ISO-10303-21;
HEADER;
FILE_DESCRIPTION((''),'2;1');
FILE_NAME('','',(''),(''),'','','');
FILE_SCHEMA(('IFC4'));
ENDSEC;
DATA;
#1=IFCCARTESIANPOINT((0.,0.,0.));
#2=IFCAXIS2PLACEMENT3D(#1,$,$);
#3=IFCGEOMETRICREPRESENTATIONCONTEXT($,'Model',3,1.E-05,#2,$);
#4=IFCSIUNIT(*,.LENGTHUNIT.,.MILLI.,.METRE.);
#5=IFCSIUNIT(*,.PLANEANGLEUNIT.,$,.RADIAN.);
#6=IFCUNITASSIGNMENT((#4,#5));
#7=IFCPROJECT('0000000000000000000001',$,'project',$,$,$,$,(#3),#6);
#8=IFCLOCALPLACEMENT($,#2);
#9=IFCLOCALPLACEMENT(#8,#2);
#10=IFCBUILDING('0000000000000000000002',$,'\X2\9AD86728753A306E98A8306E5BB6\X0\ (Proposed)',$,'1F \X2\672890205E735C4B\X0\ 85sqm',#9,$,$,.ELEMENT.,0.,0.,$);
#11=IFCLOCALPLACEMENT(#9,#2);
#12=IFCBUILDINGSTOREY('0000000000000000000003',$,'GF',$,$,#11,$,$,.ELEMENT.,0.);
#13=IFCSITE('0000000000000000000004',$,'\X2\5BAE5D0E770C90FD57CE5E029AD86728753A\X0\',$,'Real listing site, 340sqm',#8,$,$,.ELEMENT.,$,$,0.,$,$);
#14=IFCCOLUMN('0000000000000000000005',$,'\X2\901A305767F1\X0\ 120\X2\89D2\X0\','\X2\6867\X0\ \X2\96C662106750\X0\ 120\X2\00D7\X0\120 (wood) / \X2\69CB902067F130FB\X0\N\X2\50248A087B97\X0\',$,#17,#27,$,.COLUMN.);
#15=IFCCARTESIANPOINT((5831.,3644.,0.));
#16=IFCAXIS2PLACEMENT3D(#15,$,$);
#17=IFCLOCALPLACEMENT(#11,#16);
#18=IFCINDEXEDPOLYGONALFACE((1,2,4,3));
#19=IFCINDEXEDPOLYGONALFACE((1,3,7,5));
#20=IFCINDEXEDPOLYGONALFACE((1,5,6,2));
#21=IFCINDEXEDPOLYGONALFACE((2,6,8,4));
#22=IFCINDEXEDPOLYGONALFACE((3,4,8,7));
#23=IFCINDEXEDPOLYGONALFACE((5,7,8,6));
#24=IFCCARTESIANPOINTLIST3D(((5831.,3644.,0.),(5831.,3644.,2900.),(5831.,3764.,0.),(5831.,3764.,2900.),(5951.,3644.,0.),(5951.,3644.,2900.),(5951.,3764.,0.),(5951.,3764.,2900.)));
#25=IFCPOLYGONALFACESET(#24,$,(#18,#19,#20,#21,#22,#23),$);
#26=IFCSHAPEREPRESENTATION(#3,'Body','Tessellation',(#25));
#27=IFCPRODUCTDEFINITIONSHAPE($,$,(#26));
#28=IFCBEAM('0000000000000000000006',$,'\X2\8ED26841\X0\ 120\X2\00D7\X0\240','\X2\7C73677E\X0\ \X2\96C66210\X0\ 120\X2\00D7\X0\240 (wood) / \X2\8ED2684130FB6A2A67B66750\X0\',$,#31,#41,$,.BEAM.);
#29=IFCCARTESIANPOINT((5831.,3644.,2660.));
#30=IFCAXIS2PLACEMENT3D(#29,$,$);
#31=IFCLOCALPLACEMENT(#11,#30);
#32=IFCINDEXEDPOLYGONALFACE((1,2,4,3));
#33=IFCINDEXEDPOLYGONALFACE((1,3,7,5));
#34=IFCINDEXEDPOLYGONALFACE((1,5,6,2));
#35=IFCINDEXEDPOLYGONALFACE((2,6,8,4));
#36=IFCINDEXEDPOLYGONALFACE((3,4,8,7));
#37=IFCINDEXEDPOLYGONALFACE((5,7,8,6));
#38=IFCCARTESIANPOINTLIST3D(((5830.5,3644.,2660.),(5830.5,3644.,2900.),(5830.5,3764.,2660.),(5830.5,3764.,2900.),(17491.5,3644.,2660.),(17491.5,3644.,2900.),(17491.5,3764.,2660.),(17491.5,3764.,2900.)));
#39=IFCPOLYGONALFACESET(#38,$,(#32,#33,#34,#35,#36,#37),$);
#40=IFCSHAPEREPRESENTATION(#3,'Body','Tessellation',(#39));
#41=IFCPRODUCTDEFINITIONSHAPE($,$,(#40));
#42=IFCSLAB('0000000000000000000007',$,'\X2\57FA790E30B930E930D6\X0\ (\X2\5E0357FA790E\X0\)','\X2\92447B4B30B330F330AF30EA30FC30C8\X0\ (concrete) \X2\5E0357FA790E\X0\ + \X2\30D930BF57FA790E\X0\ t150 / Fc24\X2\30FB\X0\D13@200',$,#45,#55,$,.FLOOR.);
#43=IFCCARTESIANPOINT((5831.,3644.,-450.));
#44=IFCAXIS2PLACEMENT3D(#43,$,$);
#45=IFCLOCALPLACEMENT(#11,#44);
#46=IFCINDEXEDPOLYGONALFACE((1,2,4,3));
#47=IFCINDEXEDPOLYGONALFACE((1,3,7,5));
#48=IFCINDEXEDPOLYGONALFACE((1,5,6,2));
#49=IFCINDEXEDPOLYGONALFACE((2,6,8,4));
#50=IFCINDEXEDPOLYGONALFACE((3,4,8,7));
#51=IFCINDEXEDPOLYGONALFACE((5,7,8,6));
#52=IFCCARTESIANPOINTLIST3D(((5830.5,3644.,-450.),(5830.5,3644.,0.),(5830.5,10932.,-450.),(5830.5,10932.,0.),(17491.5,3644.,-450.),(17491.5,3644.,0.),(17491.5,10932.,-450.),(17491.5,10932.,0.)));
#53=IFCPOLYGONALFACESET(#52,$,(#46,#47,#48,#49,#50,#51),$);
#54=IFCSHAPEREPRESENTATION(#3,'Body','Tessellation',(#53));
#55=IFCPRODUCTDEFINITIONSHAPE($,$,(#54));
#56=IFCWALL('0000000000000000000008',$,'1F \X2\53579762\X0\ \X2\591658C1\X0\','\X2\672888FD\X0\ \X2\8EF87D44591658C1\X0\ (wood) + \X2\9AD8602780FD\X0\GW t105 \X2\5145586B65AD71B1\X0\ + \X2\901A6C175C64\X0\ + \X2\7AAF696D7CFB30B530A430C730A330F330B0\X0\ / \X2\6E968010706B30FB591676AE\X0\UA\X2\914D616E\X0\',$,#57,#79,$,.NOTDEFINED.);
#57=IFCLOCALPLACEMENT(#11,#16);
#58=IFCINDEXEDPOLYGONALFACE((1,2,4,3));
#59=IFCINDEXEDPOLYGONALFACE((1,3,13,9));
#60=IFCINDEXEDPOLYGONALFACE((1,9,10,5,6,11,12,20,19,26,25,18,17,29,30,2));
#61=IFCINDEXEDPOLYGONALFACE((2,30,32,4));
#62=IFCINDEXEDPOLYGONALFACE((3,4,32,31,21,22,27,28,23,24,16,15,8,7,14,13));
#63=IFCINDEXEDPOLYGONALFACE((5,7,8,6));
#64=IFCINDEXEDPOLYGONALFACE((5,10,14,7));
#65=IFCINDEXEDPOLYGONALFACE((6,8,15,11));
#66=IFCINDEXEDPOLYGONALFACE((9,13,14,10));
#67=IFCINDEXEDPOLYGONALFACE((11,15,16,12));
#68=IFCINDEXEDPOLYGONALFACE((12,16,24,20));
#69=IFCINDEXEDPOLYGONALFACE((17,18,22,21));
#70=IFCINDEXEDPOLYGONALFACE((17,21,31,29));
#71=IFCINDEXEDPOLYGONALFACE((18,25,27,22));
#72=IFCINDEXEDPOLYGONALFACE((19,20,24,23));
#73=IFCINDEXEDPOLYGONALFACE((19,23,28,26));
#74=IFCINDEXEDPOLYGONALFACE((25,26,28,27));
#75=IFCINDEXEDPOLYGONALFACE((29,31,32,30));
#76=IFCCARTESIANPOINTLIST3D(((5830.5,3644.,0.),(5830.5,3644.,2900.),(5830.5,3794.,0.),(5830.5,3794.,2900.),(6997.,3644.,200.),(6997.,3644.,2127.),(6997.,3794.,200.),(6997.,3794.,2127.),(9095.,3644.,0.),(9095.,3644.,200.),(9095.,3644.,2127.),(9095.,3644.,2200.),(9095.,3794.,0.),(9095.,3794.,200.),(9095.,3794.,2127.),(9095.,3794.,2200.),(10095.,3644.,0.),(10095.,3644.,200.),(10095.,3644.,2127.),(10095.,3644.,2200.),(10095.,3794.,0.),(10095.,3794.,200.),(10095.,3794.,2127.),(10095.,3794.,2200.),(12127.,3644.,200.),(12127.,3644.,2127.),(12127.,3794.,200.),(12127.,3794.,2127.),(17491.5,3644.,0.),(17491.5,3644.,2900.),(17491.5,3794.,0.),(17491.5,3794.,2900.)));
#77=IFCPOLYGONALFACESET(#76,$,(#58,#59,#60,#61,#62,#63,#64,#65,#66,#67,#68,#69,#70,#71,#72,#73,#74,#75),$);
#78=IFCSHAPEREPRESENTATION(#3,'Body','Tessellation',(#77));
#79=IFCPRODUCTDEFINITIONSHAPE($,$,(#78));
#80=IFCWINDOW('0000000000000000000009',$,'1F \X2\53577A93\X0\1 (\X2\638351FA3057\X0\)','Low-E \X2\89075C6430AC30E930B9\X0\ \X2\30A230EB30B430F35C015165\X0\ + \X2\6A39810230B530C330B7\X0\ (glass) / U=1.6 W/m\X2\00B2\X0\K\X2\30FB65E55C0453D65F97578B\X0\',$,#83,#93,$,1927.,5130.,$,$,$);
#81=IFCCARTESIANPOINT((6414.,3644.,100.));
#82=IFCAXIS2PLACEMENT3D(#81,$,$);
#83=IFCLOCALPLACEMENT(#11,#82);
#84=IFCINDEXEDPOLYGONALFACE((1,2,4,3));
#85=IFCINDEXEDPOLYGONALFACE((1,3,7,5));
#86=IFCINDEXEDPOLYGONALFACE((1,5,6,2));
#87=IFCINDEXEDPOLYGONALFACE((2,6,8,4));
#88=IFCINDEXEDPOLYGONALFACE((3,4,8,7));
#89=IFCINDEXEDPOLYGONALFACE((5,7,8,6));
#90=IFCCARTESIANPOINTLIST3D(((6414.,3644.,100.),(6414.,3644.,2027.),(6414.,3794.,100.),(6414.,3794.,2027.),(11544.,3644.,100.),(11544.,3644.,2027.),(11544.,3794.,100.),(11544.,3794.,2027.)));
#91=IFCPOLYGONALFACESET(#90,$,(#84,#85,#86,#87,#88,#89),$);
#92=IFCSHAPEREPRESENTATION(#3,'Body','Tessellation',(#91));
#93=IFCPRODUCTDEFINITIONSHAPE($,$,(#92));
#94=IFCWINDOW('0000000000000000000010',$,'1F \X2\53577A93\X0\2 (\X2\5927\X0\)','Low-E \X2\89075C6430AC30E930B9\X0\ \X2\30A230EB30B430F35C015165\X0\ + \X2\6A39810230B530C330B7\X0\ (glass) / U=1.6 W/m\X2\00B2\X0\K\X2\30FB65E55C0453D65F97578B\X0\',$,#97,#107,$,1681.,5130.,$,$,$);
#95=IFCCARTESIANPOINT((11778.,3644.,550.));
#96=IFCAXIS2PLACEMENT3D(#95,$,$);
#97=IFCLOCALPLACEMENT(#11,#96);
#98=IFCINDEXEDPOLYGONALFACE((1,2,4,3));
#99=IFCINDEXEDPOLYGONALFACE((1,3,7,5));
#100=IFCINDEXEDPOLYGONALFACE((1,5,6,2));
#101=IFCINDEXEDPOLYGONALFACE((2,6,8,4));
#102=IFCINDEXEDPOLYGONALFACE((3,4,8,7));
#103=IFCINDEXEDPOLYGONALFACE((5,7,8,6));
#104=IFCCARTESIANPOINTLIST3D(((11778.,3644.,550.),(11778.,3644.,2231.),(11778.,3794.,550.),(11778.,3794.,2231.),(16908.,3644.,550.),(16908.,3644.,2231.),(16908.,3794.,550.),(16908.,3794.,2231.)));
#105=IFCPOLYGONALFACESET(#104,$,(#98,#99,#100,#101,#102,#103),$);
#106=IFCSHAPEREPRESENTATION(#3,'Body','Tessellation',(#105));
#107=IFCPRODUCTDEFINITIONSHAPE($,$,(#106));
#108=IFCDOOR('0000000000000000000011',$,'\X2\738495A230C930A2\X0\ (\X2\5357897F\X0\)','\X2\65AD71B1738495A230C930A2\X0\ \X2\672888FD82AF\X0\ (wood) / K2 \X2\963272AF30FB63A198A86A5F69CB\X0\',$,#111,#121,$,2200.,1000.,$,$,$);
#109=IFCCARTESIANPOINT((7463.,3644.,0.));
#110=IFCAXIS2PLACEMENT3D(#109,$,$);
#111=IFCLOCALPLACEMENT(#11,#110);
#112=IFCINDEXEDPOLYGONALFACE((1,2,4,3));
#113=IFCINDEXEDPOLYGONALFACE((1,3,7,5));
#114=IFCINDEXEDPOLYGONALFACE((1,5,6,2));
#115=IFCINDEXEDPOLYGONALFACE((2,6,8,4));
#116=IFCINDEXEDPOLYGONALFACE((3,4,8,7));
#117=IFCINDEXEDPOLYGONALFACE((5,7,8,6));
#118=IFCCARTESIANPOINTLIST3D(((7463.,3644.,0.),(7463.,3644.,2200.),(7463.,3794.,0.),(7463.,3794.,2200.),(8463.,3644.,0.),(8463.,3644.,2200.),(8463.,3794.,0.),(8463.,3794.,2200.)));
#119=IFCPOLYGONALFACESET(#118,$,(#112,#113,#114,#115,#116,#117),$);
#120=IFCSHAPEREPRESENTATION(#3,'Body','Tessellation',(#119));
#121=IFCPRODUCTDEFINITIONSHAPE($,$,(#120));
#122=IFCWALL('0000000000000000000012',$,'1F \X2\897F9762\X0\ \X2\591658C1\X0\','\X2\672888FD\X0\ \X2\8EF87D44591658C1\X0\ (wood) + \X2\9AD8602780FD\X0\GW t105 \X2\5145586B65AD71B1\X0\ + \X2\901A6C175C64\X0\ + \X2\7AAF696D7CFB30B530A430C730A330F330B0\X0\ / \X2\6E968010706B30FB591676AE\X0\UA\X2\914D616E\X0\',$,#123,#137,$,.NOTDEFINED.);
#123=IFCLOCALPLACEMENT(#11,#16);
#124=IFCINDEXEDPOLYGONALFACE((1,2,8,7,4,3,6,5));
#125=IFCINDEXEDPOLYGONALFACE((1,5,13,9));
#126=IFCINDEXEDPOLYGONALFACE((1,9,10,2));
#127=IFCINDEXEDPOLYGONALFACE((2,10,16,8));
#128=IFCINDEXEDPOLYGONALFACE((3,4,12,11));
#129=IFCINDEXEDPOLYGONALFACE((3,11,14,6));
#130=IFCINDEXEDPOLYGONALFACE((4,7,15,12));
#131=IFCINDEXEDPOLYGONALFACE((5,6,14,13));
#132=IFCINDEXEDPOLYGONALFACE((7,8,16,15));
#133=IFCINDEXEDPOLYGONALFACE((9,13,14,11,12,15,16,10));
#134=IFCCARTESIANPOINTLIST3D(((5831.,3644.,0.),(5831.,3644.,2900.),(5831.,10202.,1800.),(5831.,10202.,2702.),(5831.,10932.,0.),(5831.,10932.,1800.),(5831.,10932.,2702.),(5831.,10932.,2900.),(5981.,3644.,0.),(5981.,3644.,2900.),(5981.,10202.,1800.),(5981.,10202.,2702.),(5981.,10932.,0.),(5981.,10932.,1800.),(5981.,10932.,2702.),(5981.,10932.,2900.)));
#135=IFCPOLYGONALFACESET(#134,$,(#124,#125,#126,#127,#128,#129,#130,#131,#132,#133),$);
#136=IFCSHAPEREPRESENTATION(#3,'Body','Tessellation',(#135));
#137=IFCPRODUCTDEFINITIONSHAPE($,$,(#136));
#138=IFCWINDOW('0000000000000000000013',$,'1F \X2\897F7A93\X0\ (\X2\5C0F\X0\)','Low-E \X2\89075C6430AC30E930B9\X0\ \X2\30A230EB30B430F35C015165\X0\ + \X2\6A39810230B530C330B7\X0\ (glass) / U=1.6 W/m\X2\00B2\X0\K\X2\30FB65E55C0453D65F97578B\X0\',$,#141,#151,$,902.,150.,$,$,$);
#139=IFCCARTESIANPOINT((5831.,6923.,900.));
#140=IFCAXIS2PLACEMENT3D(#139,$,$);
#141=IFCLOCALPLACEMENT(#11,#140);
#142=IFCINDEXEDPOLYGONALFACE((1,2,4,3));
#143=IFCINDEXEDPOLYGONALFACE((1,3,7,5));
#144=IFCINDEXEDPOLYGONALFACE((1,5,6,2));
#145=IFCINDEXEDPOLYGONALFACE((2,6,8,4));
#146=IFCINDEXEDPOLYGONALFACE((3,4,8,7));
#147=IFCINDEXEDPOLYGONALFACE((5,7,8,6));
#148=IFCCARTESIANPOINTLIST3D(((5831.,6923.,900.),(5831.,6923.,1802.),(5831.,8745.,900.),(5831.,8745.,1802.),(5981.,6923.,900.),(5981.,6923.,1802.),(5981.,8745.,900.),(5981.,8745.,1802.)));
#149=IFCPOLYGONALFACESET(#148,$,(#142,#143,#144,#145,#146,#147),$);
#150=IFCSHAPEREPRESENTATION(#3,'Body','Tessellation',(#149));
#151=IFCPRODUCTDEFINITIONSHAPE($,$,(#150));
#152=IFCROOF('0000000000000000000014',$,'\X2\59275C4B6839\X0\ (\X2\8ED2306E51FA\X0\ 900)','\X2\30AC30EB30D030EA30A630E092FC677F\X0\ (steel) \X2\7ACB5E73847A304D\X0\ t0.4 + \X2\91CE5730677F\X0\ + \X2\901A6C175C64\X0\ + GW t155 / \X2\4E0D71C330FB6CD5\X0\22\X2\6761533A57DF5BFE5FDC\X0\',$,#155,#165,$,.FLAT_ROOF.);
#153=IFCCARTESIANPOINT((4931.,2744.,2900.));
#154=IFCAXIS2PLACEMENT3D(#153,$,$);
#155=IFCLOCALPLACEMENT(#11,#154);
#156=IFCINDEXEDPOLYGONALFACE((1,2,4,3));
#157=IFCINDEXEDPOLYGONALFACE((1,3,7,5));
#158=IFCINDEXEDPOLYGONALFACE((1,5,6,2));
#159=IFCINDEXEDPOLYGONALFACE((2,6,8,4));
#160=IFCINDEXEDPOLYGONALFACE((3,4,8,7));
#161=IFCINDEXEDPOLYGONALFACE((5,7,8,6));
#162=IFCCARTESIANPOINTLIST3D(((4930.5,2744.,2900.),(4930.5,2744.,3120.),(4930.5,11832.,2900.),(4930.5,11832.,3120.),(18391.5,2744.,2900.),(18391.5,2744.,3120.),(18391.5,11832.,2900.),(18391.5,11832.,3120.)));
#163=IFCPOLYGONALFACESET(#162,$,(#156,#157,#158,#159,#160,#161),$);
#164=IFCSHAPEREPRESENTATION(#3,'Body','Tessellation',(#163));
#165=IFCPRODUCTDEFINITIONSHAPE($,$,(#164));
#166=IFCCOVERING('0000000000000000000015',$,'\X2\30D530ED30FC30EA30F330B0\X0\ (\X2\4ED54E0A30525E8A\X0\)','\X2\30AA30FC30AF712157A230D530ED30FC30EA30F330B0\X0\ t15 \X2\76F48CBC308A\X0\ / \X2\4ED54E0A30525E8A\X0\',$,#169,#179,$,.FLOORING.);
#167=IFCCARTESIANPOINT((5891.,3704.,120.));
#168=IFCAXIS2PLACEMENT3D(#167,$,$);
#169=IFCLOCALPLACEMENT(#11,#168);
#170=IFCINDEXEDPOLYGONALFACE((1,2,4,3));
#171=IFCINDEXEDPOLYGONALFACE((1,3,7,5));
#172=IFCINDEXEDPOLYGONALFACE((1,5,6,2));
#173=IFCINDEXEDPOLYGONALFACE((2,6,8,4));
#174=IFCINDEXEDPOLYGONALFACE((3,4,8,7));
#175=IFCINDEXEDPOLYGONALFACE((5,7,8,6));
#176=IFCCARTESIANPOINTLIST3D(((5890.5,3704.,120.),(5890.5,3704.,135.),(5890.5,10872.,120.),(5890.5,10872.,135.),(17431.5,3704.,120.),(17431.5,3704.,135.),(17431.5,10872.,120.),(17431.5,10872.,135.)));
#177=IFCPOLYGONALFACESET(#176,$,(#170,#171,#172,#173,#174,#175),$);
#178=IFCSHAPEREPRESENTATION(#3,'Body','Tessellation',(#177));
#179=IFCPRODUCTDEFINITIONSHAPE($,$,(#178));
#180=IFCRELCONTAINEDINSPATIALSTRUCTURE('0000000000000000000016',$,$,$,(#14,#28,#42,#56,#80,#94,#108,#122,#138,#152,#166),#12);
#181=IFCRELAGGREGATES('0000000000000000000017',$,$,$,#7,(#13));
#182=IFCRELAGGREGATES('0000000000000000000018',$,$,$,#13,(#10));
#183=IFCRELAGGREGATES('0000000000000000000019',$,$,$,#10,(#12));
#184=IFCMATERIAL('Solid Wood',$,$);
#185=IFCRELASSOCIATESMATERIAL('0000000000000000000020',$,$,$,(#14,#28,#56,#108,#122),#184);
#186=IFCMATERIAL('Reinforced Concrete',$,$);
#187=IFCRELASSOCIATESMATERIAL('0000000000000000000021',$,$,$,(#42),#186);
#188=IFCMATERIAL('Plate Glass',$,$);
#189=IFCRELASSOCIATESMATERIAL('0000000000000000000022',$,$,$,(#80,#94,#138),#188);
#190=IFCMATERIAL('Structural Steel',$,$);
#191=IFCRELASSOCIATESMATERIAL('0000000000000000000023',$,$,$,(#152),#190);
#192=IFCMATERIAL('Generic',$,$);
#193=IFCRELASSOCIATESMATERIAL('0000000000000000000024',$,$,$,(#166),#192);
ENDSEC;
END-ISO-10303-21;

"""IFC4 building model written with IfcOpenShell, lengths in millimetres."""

from ifc_helpers import new_model, si_unit, frame, frame_2d, origin, place, context, project, spatial, rectangle, extrude, material, element, fill, save


model = new_model("IFC4")

# Units and contexts
model_context = context("Model", 3, precision=1e-05, world=origin())
ifc_project = project(units=[si_unit("LENGTHUNIT", "METRE", prefix="MILLI"), si_unit("PLANEANGLEUNIT", "RADIAN")], contexts=[model_context])

# Site, building, storey
site_placement = place(None, origin())
site = spatial("IfcSite", under=ifc_project, at=site_placement, Name="宮崎県都城市高木町", ObjectType="Real listing site, 340sqm", CompositionType="ELEMENT", RefElevation=0.0)
building_placement = place(site_placement, origin())
building = spatial("IfcBuilding", under=site, at=building_placement, Name="高木町の風の家 (Proposed)", ObjectType="1F 木造平屋 85sqm", CompositionType="ELEMENT", ElevationOfRefHeight=0.0, ElevationOfTerrain=0.0)
storey_placement = place(building_placement, origin())
storey = spatial("IfcBuildingStorey", under=building, at=storey_placement, Name="GF", CompositionType="ELEMENT", Elevation=0.0)

# Column
ifc_material_1 = material(Name="Solid Wood")
column_1_placement = place(storey_placement, frame((5831.0, 3644.0, 0.0)))
element("IfcColumn", 1, at=column_1_placement, inside=storey, material=ifc_material_1, Name="通し柱 120角", Description="桧 集成材 120×120 (wood) / 構造柱・N値計算", PredefinedType="COLUMN", context=model_context, shape_type="SweptSolid", body=[
    extrude(rectangle(XDim=120.0, YDim=120.0, at=frame_2d((60.0, 60.0))), frame((5831.0, 3644.0, 0.0)), (0.0, 0.0, 1.0), 2900.0),
])

# Beam
beam_1_placement = place(storey_placement, frame((5831.0, 3644.0, 2660.0)))
element("IfcBeam", 2, at=beam_1_placement, inside=storey, material=ifc_material_1, Name="軒桁 120×240", Description="米松 集成 120×240 (wood) / 軒桁・横架材", PredefinedType="BEAM", context=model_context, shape_type="SweptSolid", body=[
    extrude(rectangle(XDim=11661.0, YDim=120.0, at=frame_2d((5830.0, 60.0))), frame((5831.0, 3644.0, 2660.0)), (0.0, 0.0, 1.0), 240.0),
])

# Slab
ifc_material_2 = material(Name="Reinforced Concrete")
slab_1_placement = place(storey_placement, frame((5831.0, 3644.0, -450.0)))
element("IfcSlab", 3, at=slab_1_placement, inside=storey, material=ifc_material_2, Name="基礎スラブ (布基礎)", Description="鉄筋コンクリート (concrete) 布基礎 + ベタ基礎 t150 / Fc24・D13@200", PredefinedType="FLOOR", context=model_context, shape_type="SweptSolid", body=[
    extrude(rectangle(XDim=11661.0, YDim=7288.0, at=frame_2d((5830.0, 3644.0))), frame((5831.0, 3644.0, -450.0)), (0.0, 0.0, 1.0), 450.0),
])

# Wall, openings, windows, door
wall_1_placement = place(storey_placement, frame((5831.0, 3644.0, 0.0)))
wall_1 = element("IfcWall", 4, at=wall_1_placement, inside=storey, material=ifc_material_1, Name="1F 南面 外壁", Description="木製 軸組外壁 (wood) + 高性能GW t105 充填断熱 + 通気層 + 窯業系サイディング / 準耐火・外皮UA配慮", PredefinedType="NOTDEFINED", context=model_context, shape_type="SweptSolid", body=[
    extrude(rectangle(XDim=11661.0, YDim=150.0, at=frame_2d((5830.0, 75.0))), frame((5831.0, 3644.0, 0.0)), (0.0, 0.0, 1.0), 2900.0),
])
opening_1_placement = place(storey_placement, frame((6414.0, 3644.0, 100.0)))
opening_1 = element("IfcOpeningElement", 5, at=opening_1_placement, cuts=wall_1, PredefinedType="NOTDEFINED", context=model_context, shape_type="SweptSolid", body=[
    extrude(rectangle(XDim=5130.0, YDim=150.0, at=frame_2d((2565.0, 75.0))), frame((6414.0, 3644.0, 100.0)), (0.0, 0.0, 1.0), 1927.0),
])
opening_2_placement = place(storey_placement, frame((11778.0, 3644.0, 550.0)))
opening_2 = element("IfcOpeningElement", 6, at=opening_2_placement, cuts=wall_1, PredefinedType="NOTDEFINED", context=model_context, shape_type="SweptSolid", body=[
    extrude(rectangle(XDim=5130.0, YDim=150.0, at=frame_2d((2565.0, 75.0))), frame((11778.0, 3644.0, 550.0)), (0.0, 0.0, 1.0), 1681.0),
])
opening_3_placement = place(storey_placement, frame((7463.0, 3644.0, 0.0)))
opening_3 = element("IfcOpeningElement", 7, at=opening_3_placement, cuts=wall_1, PredefinedType="NOTDEFINED", context=model_context, shape_type="SweptSolid", body=[
    extrude(rectangle(XDim=1000.0, YDim=150.0, at=frame_2d((500.0, 75.0))), frame((7463.0, 3644.0, 0.0)), (0.0, 0.0, 1.0), 2200.0),
])
ifc_material_3 = material(Name="Plate Glass")
window_1_placement = place(storey_placement, frame((6414.0, 3644.0, 100.0)))
window_1 = element("IfcWindow", 8, at=window_1_placement, inside=storey, material=ifc_material_3, Name="1F 南窓1 (掃出し)", Description="Low-E 複層ガラス アルゴン封入 + 樹脂サッシ (glass) / U=1.6 W/m²K・日射取得型", OverallHeight=1927.0, OverallWidth=5130.0, context=model_context, shape_type="SweptSolid", body=[
    extrude(rectangle(XDim=5130.0, YDim=150.0, at=frame_2d((2565.0, 75.0))), frame((6414.0, 3644.0, 100.0)), (0.0, 0.0, 1.0), 1927.0),
])
fill(opening_1, window_1)
window_2_placement = place(storey_placement, frame((11778.0, 3644.0, 550.0)))
window_2 = element("IfcWindow", 9, at=window_2_placement, inside=storey, material=ifc_material_3, Name="1F 南窓2 (大)", Description="Low-E 複層ガラス アルゴン封入 + 樹脂サッシ (glass) / U=1.6 W/m²K・日射取得型", OverallHeight=1681.0, OverallWidth=5130.0, context=model_context, shape_type="SweptSolid", body=[
    extrude(rectangle(XDim=5130.0, YDim=150.0, at=frame_2d((2565.0, 75.0))), frame((11778.0, 3644.0, 550.0)), (0.0, 0.0, 1.0), 1681.0),
])
fill(opening_2, window_2)
door_placement = place(storey_placement, frame((7463.0, 3644.0, 0.0)))
door = element("IfcDoor", 10, at=door_placement, inside=storey, material=ifc_material_1, Name="玄関ドア (南西)", Description="断熱玄関ドア 木製芯 (wood) / K2 防犯・採風機構", OverallHeight=2200.0, OverallWidth=1000.0, context=model_context, shape_type="SweptSolid", body=[
    extrude(rectangle(XDim=1000.0, YDim=150.0, at=frame_2d((500.0, 75.0))), frame((7463.0, 3644.0, 0.0)), (0.0, 0.0, 1.0), 2200.0),
])
fill(opening_3, door)

# Wall, opening, window
wall_2_placement = place(storey_placement, frame((5831.0, 3644.0, 0.0)))
wall_2 = element("IfcWall", 11, at=wall_2_placement, inside=storey, material=ifc_material_1, Name="1F 西面 外壁", Description="木製 軸組外壁 (wood) + 高性能GW t105 充填断熱 + 通気層 + 窯業系サイディング / 準耐火・外皮UA配慮", PredefinedType="NOTDEFINED", context=model_context, shape_type="SweptSolid", body=[
    extrude(rectangle(XDim=150.0, YDim=7288.0, at=frame_2d((75.0, 3644.0))), frame((5831.0, 3644.0, 0.0)), (0.0, 0.0, 1.0), 2900.0),
])
opening_4_placement = place(storey_placement, frame((5831.0, 6923.0, 900.0)))
opening_4 = element("IfcOpeningElement", 12, at=opening_4_placement, cuts=wall_2, PredefinedType="NOTDEFINED", context=model_context, shape_type="SweptSolid", body=[
    extrude(rectangle(XDim=150.0, YDim=1822.0, at=frame_2d((75.0, 911.0))), frame((5831.0, 6923.0, 900.0)), (0.0, 0.0, 1.0), 902.0),
])
window_3_placement = place(storey_placement, frame((5831.0, 6923.0, 900.0)))
window_3 = element("IfcWindow", 13, at=window_3_placement, inside=storey, material=ifc_material_3, Name="1F 西窓 (小)", Description="Low-E 複層ガラス アルゴン封入 + 樹脂サッシ (glass) / U=1.6 W/m²K・日射取得型", OverallHeight=902.0, OverallWidth=150.0, context=model_context, shape_type="SweptSolid", body=[
    extrude(rectangle(XDim=150.0, YDim=1822.0, at=frame_2d((75.0, 911.0))), frame((5831.0, 6923.0, 900.0)), (0.0, 0.0, 1.0), 902.0),
])
fill(opening_4, window_3)

# Roof
ifc_material_4 = material(Name="Structural Steel")
roof_placement = place(storey_placement, frame((4931.0, 2744.0, 2900.0)))
element("IfcRoof", 14, at=roof_placement, inside=storey, material=ifc_material_4, Name="大屋根 (軒の出 900)", Description="ガルバリウム鋼板 (steel) 立平葺き t0.4 + 野地板 + 通気層 + GW t155 / 不燃・法22条区域対応", PredefinedType="FLAT_ROOF", context=model_context, shape_type="SweptSolid", body=[
    extrude(rectangle(XDim=13461.0, YDim=9088.0, at=frame_2d((6730.0, 4544.0))), frame((4931.0, 2744.0, 2900.0)), (0.0, 0.0, 1.0), 220.0),
])

# Covering
ifc_material_5 = material(Name="Generic")
covering_1_placement = place(storey_placement, frame((5891.0, 3704.0, 120.0)))
element("IfcCovering", 15, at=covering_1_placement, inside=storey, material=ifc_material_5, Name="フローリング (仕上げ床)", Description="オーク無垢フローリング t15 直貼り / 仕上げ床", PredefinedType="FLOORING", context=model_context, shape_type="SweptSolid", body=[
    extrude(rectangle(XDim=11541.0, YDim=7168.0, at=frame_2d((5770.0, 3584.0))), frame((5891.0, 3704.0, 120.0)), (0.0, 0.0, 1.0), 15.0),
])

save(model, "model.ifc")
